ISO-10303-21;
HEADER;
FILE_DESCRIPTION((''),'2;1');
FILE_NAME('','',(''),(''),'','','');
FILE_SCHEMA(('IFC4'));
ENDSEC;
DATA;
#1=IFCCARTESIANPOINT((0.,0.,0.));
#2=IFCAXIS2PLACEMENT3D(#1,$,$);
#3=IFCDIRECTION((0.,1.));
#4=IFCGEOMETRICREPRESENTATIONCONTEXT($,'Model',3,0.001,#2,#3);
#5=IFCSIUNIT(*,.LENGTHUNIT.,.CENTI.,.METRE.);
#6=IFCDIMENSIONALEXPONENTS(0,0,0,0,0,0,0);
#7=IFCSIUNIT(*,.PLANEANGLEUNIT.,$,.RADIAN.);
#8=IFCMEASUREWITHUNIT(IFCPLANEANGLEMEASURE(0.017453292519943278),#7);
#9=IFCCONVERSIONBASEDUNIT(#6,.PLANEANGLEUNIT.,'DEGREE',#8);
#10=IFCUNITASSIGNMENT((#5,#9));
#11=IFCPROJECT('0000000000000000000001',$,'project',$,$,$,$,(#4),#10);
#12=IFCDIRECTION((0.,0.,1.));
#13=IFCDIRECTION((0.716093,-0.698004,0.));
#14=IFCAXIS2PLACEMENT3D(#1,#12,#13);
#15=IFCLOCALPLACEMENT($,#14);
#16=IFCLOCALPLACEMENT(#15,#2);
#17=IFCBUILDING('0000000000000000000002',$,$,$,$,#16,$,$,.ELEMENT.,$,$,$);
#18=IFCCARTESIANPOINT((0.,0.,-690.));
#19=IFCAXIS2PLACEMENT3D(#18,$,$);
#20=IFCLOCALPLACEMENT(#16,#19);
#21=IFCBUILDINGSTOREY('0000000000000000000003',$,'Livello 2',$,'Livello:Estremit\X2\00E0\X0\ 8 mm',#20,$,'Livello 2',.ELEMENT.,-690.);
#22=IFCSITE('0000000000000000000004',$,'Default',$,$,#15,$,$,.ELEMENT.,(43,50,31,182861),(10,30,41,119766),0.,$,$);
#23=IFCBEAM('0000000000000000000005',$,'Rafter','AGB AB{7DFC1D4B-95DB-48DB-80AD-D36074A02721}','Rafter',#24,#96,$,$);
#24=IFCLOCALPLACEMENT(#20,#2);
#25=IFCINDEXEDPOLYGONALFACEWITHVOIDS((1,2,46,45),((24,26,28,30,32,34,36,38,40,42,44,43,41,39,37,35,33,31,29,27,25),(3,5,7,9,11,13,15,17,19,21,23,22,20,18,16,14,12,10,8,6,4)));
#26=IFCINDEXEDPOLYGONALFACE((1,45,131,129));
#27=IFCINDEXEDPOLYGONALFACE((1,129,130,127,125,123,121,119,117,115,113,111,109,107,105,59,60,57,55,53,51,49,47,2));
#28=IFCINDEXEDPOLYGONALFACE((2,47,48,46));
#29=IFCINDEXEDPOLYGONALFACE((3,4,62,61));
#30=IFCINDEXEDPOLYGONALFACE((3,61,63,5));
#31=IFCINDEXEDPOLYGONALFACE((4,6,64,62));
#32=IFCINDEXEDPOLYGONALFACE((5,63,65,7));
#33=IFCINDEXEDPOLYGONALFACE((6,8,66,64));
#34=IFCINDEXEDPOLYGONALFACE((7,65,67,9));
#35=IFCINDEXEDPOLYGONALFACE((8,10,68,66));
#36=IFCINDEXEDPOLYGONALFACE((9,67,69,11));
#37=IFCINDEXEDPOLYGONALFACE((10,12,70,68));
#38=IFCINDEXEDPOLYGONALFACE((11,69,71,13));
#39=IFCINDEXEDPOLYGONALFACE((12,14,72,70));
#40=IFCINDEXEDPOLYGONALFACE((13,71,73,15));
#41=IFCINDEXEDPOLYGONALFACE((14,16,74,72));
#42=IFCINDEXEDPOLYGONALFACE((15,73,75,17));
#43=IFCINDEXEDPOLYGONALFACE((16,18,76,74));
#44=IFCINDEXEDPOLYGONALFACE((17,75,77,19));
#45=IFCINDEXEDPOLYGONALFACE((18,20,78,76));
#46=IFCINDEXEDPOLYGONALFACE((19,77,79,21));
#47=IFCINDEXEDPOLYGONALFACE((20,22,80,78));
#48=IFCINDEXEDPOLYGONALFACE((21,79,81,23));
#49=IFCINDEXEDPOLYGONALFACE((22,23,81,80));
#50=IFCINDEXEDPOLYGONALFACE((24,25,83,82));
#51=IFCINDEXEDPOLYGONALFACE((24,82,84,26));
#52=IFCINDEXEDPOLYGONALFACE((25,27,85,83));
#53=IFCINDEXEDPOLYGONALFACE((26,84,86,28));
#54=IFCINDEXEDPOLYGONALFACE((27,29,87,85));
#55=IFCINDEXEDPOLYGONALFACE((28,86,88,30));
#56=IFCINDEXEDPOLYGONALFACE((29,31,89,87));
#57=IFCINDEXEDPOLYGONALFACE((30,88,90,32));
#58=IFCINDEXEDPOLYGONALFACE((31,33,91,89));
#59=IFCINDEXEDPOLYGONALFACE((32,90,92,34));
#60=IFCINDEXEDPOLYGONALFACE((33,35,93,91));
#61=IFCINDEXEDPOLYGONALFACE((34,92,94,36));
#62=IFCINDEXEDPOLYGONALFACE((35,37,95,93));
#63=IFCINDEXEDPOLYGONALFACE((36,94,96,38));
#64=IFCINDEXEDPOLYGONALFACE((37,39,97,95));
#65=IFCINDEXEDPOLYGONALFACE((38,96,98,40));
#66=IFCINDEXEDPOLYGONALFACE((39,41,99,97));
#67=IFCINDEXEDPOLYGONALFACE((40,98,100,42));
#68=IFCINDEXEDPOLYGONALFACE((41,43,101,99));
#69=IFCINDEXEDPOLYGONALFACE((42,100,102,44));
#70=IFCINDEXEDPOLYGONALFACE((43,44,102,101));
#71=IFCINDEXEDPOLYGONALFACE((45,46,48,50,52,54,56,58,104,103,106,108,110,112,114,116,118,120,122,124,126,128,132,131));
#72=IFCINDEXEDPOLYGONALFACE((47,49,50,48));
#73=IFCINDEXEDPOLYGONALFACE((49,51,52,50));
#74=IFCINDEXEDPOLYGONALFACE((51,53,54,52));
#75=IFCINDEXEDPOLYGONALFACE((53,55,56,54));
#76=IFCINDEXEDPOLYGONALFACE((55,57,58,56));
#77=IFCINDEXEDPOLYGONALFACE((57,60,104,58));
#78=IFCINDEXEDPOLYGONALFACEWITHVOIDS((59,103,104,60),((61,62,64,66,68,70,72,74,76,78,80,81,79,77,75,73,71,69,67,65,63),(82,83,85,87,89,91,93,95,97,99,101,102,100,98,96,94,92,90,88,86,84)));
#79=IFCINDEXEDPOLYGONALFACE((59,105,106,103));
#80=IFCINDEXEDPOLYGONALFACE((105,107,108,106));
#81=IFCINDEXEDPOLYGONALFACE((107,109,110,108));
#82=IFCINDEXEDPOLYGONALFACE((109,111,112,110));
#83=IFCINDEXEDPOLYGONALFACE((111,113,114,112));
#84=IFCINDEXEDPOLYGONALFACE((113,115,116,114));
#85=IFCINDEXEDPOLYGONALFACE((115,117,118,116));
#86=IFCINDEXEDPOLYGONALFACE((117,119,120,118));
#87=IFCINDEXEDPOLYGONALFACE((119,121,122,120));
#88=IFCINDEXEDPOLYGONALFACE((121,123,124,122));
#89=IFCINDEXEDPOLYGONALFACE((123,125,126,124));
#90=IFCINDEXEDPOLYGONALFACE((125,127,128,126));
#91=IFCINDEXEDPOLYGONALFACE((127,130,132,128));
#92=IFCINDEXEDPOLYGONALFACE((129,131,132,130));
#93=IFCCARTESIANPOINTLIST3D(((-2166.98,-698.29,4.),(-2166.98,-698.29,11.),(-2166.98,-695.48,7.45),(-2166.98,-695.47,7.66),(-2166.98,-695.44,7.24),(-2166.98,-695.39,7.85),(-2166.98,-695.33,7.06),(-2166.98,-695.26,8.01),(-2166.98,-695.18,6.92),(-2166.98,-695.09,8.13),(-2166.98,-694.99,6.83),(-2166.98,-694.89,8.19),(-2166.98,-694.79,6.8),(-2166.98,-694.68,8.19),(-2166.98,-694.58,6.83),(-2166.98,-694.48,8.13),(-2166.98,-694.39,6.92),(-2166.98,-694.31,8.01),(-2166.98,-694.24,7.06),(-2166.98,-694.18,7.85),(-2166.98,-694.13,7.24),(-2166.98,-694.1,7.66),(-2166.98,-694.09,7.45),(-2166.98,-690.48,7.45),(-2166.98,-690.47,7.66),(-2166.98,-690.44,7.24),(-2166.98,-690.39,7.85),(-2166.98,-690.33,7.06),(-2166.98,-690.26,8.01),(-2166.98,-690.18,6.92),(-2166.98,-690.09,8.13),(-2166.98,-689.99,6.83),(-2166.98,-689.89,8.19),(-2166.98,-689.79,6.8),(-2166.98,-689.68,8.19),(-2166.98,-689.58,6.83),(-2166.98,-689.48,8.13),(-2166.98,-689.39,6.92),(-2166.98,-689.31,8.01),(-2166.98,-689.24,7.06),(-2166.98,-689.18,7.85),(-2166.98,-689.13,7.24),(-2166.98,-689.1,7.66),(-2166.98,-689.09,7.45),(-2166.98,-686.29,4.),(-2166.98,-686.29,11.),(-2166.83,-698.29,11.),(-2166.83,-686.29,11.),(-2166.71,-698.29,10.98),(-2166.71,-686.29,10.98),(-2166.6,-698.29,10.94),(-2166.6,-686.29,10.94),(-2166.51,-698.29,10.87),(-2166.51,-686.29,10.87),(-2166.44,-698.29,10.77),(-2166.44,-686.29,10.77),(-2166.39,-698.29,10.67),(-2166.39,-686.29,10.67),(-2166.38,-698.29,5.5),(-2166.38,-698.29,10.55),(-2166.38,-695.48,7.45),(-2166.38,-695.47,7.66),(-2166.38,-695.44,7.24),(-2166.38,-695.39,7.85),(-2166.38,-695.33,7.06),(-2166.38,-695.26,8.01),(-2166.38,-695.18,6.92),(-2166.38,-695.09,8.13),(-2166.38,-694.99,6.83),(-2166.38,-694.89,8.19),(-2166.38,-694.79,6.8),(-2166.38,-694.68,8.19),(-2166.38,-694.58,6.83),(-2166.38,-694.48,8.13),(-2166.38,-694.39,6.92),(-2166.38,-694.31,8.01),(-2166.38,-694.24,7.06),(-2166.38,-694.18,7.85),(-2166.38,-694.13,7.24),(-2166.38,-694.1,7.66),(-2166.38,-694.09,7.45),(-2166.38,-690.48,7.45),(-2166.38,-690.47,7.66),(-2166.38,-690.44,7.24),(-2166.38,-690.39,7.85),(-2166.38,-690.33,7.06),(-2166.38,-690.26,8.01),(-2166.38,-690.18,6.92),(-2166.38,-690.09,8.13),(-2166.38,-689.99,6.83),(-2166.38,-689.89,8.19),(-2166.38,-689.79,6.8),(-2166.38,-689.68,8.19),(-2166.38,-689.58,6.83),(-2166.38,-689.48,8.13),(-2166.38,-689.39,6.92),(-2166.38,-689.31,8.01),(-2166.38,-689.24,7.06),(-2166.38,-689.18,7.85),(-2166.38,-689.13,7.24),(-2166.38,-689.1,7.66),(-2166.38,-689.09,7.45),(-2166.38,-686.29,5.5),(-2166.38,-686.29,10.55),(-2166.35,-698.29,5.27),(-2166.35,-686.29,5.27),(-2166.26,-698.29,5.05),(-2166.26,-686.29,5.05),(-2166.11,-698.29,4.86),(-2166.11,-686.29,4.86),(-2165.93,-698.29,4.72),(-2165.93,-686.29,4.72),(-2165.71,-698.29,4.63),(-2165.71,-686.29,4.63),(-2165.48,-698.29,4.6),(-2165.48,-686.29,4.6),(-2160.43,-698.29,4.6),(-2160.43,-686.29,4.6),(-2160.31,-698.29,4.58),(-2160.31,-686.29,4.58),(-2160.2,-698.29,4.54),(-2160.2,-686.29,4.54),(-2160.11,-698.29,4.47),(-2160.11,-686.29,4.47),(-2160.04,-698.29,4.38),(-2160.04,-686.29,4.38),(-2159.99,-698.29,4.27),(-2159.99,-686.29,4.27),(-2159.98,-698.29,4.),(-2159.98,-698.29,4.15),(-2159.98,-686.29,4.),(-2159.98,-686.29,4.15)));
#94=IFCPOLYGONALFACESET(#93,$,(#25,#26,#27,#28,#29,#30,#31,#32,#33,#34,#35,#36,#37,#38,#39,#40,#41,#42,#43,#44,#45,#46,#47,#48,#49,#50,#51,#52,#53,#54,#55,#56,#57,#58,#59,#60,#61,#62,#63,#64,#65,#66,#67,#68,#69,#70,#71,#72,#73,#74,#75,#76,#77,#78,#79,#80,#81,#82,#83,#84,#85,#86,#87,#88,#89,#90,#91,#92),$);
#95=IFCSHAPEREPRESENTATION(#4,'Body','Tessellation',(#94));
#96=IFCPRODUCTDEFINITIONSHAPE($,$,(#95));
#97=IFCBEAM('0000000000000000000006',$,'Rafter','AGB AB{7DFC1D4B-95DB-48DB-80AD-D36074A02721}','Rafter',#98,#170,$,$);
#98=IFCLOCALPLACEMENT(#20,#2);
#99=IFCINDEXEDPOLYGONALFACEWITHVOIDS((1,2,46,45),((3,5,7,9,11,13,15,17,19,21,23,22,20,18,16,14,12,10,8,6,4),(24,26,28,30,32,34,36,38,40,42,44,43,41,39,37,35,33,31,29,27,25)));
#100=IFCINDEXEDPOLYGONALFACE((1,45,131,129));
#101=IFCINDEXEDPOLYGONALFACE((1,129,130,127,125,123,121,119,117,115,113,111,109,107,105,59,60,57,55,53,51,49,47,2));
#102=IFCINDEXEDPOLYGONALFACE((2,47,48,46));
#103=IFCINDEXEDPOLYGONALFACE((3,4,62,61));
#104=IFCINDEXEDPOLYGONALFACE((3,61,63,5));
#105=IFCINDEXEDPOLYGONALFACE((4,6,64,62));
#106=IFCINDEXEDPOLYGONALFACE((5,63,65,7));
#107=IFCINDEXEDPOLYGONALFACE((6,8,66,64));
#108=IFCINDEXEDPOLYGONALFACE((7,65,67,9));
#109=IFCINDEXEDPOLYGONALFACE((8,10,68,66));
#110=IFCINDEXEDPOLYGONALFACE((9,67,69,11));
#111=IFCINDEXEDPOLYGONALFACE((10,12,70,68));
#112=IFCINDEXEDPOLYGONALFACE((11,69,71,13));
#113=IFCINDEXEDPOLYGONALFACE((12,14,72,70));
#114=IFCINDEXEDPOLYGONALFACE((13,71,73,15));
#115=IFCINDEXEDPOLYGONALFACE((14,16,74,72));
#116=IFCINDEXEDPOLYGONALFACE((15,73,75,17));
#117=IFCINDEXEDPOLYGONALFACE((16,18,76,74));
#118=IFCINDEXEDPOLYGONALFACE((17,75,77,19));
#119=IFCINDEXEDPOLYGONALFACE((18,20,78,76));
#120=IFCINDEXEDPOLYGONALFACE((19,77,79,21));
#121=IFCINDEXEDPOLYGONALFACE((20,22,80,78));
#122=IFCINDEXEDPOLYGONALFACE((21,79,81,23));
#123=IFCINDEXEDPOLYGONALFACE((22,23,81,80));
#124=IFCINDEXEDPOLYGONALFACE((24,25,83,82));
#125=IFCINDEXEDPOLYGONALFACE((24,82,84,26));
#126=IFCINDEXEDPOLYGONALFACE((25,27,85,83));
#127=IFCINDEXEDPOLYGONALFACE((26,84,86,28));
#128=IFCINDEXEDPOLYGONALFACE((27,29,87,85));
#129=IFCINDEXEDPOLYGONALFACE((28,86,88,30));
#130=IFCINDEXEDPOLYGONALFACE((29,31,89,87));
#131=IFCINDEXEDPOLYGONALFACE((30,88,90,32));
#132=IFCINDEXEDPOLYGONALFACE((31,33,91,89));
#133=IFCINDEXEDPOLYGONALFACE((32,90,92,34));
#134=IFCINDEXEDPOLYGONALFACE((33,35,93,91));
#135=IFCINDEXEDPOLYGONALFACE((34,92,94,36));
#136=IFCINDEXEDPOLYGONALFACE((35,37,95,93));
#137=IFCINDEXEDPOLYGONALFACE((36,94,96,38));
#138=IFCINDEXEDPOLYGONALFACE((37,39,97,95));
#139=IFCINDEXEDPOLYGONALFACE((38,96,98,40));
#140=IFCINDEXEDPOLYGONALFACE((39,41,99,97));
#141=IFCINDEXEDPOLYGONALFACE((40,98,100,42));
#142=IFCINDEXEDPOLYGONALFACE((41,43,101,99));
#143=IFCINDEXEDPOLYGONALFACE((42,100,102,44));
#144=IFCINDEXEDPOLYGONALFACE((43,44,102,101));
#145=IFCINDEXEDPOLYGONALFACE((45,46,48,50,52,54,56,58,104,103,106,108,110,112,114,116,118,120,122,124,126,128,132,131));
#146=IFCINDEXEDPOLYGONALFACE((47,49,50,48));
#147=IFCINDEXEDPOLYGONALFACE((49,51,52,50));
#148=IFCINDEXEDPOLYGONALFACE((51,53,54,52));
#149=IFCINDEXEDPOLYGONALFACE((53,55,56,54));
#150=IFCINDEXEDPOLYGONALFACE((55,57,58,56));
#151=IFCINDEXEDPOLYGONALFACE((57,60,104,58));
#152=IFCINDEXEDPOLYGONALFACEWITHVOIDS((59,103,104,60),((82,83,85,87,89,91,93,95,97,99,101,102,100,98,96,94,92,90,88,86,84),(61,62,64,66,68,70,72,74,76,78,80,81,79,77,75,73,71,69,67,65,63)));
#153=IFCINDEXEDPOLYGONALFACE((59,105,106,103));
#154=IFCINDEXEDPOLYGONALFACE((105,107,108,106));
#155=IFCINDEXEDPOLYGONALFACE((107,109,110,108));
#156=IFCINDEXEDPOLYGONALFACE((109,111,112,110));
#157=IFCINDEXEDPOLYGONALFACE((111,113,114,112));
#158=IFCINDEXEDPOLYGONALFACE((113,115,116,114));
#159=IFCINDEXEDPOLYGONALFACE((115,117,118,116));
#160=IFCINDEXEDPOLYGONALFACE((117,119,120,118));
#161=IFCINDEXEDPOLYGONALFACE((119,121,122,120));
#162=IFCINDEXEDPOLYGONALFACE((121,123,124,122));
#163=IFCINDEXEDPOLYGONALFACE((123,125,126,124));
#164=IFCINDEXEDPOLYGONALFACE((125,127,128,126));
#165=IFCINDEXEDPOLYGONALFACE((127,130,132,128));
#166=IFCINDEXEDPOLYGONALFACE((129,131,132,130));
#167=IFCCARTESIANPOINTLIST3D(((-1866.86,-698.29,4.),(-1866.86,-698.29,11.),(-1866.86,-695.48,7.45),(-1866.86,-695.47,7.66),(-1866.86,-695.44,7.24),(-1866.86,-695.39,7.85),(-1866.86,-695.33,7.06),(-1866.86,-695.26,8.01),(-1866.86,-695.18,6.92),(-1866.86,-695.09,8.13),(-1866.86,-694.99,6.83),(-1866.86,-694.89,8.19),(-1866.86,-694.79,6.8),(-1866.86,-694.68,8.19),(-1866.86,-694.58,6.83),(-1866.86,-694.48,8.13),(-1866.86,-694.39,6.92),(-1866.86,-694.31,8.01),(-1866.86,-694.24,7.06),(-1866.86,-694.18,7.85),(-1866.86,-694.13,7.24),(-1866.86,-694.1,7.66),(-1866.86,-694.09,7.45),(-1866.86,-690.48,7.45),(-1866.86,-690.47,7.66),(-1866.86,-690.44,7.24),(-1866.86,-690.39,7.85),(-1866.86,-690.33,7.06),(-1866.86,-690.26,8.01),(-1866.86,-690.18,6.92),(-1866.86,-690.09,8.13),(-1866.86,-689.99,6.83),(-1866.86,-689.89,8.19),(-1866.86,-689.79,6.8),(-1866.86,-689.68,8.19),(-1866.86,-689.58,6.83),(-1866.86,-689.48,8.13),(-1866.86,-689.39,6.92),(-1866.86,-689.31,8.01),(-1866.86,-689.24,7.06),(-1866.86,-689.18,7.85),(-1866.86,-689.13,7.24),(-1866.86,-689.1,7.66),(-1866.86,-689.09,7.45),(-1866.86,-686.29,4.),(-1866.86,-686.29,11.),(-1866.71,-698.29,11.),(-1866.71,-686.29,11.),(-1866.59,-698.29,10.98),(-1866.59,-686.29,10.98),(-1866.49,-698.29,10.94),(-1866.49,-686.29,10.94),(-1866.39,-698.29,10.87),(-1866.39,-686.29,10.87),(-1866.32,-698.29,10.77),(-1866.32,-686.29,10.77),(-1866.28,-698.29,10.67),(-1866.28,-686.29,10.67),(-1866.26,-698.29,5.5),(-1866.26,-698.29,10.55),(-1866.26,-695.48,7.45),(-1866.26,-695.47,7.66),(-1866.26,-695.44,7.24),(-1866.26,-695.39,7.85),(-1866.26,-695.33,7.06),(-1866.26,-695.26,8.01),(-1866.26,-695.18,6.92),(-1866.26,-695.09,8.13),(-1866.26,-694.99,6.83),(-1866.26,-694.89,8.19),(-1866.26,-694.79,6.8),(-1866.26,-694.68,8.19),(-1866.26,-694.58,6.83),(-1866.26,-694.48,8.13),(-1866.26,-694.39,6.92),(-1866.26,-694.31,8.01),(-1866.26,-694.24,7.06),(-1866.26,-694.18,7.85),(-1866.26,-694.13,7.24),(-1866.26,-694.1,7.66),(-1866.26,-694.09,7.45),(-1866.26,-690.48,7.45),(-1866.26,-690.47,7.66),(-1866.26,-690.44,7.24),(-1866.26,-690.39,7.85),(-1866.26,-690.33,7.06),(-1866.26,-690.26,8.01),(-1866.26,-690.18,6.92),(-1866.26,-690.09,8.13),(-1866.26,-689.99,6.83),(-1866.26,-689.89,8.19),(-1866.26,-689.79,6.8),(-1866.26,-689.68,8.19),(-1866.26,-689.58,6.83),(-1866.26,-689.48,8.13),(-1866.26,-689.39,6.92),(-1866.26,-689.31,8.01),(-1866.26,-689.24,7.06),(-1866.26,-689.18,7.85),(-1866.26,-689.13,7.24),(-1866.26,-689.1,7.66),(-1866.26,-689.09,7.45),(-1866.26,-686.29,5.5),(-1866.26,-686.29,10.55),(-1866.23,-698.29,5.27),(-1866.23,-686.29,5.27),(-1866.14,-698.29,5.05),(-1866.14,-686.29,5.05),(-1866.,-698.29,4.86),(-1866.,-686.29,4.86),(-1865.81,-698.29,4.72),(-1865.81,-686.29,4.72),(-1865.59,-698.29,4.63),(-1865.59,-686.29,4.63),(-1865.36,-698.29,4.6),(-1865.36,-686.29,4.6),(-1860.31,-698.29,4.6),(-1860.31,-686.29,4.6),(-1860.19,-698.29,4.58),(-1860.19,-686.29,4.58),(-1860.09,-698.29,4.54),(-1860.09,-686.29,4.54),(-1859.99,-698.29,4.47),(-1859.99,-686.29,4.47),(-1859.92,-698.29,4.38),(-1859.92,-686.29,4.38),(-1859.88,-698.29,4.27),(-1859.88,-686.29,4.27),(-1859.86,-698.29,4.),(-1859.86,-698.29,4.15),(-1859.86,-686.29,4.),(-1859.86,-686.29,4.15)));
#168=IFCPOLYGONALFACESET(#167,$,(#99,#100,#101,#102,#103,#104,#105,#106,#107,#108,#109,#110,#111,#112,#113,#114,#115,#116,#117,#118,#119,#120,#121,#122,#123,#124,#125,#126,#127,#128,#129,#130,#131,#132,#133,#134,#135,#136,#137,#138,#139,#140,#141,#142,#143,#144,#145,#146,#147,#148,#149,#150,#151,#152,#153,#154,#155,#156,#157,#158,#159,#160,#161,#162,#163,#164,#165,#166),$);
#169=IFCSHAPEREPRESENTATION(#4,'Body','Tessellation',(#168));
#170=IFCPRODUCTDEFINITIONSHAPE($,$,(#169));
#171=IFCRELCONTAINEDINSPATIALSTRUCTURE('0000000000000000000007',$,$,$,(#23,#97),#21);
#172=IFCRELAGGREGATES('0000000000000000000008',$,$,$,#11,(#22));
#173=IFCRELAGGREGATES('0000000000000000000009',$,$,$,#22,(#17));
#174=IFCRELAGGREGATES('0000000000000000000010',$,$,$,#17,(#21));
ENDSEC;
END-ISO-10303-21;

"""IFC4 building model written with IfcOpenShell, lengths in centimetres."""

from ifc_helpers import new_model, entity, si_unit, converted_unit, direction, frame, frame_2d, origin, place, context, project, spatial, circle, l_section, extrude, element, save


model = new_model("IFC4")

# Units and contexts
model_context = context("Model", 3, precision=0.001, world=origin(), true_north=direction((0.0, 1.0)))
ifc_project = project(units=[si_unit("LENGTHUNIT", "METRE", prefix="CENTI"), converted_unit("PLANEANGLEUNIT", "DEGREE", entity("IfcPlaneAngleMeasure", 0.017453292519943278), si_unit("PLANEANGLEUNIT", "RADIAN"), dimensions=[0, 0, 0, 0, 0, 0, 0])], contexts=[model_context])

# Site, building, storey
site_placement = place(None, frame((0.0, 0.0, 0.0), z_axis=(0.0, 0.0, 1.0), x_axis=(0.716093, -0.698004, 0.0)))
site = spatial("IfcSite", under=ifc_project, at=site_placement, Name="Default", CompositionType="ELEMENT", RefLatitude=(43, 50, 31, 182861), RefLongitude=(10, 30, 41, 119766), RefElevation=0.0)
building_placement = place(site_placement, origin())
building = spatial("IfcBuilding", under=site, at=building_placement, CompositionType="ELEMENT")
storey_placement = place(building_placement, frame((0.0, 0.0, -690.0)))
storey = spatial("IfcBuildingStorey", under=building, at=storey_placement, Name="Livello 2", ObjectType="Livello:Estremità 8 mm", LongName="Livello 2", CompositionType="ELEMENT", Elevation=-690.0)

# Beams, openings
beam_1_placement = place(storey_placement, frame((-2165.05, -698.29, 5.93), z_axis=(0.0, -1.0, 0.0), x_axis=(1.0, 0.0, 0.0)))
beam_1 = element("IfcBeam", 1, at=beam_1_placement, inside=storey, Name="Rafter", Description="AGB AB{7DFC1D4B-95DB-48DB-80AD-D36074A02721}", ObjectType="Rafter", context=model_context, shape_type="SweptSolid", body=[
    extrude(l_section(Depth=7.0, Width=7.0, Thickness=0.6, FilletRadius=0.9, EdgeRadius=0.45, at=frame_2d((1.57, 1.57))), origin(), (0.0, 0.0, -1.0), 12.0),
])
opening_1_placement = place(beam_1_placement, frame((-1.98, 1.57, -4.2), z_axis=(-1.0, 0.0, 0.0), x_axis=(0.0, -1.0, 0.0)))
element("IfcOpeningElement", 2, at=opening_1_placement, cuts=beam_1, ObjectType="Opening", context=model_context, shape_type="SweptSolid", body=[
    extrude(circle(Radius=0.7, at=frame_2d((0.0, 0.7), x_axis=(1.0, 0.0))), origin(), (0.0, 0.0, -1.0), 0.7),
])
opening_2_placement = place(beam_1_placement, frame((-1.98, 1.57, -9.2), z_axis=(-1.0, 0.0, 0.0), x_axis=(0.0, -1.0, 0.0)))
element("IfcOpeningElement", 3, at=opening_2_placement, cuts=beam_1, ObjectType="Opening", context=model_context, shape_type="SweptSolid", body=[
    extrude(circle(Radius=0.7, at=frame_2d((0.0, 0.7), x_axis=(1.0, 0.0))), origin(), (0.0, 0.0, -1.0), 0.7),
])
beam_2_placement = place(storey_placement, frame((-1864.93, -698.29, 5.93), z_axis=(0.0, -1.0, 0.0), x_axis=(1.0, 0.0, 0.0)))
beam_2 = element("IfcBeam", 4, at=beam_2_placement, inside=storey, Name="Rafter", Description="AGB AB{7DFC1D4B-95DB-48DB-80AD-D36074A02721}", ObjectType="Rafter", context=model_context, shape_type="SweptSolid", body=[
    extrude(l_section(Depth=7.0, Width=7.0, Thickness=0.6, FilletRadius=0.9, EdgeRadius=0.45, at=frame_2d((1.57, 1.57))), origin(), (0.0, 0.0, -1.0), 12.0),
])
opening_3_placement = place(beam_2_placement, frame((-1.98, 1.57, -4.2), z_axis=(-1.0, 0.0, 0.0), x_axis=(0.0, -1.0, 0.0)))
element("IfcOpeningElement", 5, at=opening_3_placement, cuts=beam_2, ObjectType="Opening", context=model_context, shape_type="SweptSolid", body=[
    extrude(circle(Radius=0.7, at=frame_2d((0.0, 0.7), x_axis=(1.0, 0.0))), origin(), (0.0, 0.0, -1.0), 0.7),
])
opening_4_placement = place(beam_2_placement, frame((-1.98, 1.57, -9.2), z_axis=(-1.0, 0.0, 0.0), x_axis=(0.0, -1.0, 0.0)))
element("IfcOpeningElement", 6, at=opening_4_placement, cuts=beam_2, ObjectType="Opening", context=model_context, shape_type="SweptSolid", body=[
    extrude(circle(Radius=0.7, at=frame_2d((0.0, 0.7), x_axis=(1.0, 0.0))), origin(), (0.0, 0.0, -1.0), 0.7),
])

save(model, "model.ifc")
